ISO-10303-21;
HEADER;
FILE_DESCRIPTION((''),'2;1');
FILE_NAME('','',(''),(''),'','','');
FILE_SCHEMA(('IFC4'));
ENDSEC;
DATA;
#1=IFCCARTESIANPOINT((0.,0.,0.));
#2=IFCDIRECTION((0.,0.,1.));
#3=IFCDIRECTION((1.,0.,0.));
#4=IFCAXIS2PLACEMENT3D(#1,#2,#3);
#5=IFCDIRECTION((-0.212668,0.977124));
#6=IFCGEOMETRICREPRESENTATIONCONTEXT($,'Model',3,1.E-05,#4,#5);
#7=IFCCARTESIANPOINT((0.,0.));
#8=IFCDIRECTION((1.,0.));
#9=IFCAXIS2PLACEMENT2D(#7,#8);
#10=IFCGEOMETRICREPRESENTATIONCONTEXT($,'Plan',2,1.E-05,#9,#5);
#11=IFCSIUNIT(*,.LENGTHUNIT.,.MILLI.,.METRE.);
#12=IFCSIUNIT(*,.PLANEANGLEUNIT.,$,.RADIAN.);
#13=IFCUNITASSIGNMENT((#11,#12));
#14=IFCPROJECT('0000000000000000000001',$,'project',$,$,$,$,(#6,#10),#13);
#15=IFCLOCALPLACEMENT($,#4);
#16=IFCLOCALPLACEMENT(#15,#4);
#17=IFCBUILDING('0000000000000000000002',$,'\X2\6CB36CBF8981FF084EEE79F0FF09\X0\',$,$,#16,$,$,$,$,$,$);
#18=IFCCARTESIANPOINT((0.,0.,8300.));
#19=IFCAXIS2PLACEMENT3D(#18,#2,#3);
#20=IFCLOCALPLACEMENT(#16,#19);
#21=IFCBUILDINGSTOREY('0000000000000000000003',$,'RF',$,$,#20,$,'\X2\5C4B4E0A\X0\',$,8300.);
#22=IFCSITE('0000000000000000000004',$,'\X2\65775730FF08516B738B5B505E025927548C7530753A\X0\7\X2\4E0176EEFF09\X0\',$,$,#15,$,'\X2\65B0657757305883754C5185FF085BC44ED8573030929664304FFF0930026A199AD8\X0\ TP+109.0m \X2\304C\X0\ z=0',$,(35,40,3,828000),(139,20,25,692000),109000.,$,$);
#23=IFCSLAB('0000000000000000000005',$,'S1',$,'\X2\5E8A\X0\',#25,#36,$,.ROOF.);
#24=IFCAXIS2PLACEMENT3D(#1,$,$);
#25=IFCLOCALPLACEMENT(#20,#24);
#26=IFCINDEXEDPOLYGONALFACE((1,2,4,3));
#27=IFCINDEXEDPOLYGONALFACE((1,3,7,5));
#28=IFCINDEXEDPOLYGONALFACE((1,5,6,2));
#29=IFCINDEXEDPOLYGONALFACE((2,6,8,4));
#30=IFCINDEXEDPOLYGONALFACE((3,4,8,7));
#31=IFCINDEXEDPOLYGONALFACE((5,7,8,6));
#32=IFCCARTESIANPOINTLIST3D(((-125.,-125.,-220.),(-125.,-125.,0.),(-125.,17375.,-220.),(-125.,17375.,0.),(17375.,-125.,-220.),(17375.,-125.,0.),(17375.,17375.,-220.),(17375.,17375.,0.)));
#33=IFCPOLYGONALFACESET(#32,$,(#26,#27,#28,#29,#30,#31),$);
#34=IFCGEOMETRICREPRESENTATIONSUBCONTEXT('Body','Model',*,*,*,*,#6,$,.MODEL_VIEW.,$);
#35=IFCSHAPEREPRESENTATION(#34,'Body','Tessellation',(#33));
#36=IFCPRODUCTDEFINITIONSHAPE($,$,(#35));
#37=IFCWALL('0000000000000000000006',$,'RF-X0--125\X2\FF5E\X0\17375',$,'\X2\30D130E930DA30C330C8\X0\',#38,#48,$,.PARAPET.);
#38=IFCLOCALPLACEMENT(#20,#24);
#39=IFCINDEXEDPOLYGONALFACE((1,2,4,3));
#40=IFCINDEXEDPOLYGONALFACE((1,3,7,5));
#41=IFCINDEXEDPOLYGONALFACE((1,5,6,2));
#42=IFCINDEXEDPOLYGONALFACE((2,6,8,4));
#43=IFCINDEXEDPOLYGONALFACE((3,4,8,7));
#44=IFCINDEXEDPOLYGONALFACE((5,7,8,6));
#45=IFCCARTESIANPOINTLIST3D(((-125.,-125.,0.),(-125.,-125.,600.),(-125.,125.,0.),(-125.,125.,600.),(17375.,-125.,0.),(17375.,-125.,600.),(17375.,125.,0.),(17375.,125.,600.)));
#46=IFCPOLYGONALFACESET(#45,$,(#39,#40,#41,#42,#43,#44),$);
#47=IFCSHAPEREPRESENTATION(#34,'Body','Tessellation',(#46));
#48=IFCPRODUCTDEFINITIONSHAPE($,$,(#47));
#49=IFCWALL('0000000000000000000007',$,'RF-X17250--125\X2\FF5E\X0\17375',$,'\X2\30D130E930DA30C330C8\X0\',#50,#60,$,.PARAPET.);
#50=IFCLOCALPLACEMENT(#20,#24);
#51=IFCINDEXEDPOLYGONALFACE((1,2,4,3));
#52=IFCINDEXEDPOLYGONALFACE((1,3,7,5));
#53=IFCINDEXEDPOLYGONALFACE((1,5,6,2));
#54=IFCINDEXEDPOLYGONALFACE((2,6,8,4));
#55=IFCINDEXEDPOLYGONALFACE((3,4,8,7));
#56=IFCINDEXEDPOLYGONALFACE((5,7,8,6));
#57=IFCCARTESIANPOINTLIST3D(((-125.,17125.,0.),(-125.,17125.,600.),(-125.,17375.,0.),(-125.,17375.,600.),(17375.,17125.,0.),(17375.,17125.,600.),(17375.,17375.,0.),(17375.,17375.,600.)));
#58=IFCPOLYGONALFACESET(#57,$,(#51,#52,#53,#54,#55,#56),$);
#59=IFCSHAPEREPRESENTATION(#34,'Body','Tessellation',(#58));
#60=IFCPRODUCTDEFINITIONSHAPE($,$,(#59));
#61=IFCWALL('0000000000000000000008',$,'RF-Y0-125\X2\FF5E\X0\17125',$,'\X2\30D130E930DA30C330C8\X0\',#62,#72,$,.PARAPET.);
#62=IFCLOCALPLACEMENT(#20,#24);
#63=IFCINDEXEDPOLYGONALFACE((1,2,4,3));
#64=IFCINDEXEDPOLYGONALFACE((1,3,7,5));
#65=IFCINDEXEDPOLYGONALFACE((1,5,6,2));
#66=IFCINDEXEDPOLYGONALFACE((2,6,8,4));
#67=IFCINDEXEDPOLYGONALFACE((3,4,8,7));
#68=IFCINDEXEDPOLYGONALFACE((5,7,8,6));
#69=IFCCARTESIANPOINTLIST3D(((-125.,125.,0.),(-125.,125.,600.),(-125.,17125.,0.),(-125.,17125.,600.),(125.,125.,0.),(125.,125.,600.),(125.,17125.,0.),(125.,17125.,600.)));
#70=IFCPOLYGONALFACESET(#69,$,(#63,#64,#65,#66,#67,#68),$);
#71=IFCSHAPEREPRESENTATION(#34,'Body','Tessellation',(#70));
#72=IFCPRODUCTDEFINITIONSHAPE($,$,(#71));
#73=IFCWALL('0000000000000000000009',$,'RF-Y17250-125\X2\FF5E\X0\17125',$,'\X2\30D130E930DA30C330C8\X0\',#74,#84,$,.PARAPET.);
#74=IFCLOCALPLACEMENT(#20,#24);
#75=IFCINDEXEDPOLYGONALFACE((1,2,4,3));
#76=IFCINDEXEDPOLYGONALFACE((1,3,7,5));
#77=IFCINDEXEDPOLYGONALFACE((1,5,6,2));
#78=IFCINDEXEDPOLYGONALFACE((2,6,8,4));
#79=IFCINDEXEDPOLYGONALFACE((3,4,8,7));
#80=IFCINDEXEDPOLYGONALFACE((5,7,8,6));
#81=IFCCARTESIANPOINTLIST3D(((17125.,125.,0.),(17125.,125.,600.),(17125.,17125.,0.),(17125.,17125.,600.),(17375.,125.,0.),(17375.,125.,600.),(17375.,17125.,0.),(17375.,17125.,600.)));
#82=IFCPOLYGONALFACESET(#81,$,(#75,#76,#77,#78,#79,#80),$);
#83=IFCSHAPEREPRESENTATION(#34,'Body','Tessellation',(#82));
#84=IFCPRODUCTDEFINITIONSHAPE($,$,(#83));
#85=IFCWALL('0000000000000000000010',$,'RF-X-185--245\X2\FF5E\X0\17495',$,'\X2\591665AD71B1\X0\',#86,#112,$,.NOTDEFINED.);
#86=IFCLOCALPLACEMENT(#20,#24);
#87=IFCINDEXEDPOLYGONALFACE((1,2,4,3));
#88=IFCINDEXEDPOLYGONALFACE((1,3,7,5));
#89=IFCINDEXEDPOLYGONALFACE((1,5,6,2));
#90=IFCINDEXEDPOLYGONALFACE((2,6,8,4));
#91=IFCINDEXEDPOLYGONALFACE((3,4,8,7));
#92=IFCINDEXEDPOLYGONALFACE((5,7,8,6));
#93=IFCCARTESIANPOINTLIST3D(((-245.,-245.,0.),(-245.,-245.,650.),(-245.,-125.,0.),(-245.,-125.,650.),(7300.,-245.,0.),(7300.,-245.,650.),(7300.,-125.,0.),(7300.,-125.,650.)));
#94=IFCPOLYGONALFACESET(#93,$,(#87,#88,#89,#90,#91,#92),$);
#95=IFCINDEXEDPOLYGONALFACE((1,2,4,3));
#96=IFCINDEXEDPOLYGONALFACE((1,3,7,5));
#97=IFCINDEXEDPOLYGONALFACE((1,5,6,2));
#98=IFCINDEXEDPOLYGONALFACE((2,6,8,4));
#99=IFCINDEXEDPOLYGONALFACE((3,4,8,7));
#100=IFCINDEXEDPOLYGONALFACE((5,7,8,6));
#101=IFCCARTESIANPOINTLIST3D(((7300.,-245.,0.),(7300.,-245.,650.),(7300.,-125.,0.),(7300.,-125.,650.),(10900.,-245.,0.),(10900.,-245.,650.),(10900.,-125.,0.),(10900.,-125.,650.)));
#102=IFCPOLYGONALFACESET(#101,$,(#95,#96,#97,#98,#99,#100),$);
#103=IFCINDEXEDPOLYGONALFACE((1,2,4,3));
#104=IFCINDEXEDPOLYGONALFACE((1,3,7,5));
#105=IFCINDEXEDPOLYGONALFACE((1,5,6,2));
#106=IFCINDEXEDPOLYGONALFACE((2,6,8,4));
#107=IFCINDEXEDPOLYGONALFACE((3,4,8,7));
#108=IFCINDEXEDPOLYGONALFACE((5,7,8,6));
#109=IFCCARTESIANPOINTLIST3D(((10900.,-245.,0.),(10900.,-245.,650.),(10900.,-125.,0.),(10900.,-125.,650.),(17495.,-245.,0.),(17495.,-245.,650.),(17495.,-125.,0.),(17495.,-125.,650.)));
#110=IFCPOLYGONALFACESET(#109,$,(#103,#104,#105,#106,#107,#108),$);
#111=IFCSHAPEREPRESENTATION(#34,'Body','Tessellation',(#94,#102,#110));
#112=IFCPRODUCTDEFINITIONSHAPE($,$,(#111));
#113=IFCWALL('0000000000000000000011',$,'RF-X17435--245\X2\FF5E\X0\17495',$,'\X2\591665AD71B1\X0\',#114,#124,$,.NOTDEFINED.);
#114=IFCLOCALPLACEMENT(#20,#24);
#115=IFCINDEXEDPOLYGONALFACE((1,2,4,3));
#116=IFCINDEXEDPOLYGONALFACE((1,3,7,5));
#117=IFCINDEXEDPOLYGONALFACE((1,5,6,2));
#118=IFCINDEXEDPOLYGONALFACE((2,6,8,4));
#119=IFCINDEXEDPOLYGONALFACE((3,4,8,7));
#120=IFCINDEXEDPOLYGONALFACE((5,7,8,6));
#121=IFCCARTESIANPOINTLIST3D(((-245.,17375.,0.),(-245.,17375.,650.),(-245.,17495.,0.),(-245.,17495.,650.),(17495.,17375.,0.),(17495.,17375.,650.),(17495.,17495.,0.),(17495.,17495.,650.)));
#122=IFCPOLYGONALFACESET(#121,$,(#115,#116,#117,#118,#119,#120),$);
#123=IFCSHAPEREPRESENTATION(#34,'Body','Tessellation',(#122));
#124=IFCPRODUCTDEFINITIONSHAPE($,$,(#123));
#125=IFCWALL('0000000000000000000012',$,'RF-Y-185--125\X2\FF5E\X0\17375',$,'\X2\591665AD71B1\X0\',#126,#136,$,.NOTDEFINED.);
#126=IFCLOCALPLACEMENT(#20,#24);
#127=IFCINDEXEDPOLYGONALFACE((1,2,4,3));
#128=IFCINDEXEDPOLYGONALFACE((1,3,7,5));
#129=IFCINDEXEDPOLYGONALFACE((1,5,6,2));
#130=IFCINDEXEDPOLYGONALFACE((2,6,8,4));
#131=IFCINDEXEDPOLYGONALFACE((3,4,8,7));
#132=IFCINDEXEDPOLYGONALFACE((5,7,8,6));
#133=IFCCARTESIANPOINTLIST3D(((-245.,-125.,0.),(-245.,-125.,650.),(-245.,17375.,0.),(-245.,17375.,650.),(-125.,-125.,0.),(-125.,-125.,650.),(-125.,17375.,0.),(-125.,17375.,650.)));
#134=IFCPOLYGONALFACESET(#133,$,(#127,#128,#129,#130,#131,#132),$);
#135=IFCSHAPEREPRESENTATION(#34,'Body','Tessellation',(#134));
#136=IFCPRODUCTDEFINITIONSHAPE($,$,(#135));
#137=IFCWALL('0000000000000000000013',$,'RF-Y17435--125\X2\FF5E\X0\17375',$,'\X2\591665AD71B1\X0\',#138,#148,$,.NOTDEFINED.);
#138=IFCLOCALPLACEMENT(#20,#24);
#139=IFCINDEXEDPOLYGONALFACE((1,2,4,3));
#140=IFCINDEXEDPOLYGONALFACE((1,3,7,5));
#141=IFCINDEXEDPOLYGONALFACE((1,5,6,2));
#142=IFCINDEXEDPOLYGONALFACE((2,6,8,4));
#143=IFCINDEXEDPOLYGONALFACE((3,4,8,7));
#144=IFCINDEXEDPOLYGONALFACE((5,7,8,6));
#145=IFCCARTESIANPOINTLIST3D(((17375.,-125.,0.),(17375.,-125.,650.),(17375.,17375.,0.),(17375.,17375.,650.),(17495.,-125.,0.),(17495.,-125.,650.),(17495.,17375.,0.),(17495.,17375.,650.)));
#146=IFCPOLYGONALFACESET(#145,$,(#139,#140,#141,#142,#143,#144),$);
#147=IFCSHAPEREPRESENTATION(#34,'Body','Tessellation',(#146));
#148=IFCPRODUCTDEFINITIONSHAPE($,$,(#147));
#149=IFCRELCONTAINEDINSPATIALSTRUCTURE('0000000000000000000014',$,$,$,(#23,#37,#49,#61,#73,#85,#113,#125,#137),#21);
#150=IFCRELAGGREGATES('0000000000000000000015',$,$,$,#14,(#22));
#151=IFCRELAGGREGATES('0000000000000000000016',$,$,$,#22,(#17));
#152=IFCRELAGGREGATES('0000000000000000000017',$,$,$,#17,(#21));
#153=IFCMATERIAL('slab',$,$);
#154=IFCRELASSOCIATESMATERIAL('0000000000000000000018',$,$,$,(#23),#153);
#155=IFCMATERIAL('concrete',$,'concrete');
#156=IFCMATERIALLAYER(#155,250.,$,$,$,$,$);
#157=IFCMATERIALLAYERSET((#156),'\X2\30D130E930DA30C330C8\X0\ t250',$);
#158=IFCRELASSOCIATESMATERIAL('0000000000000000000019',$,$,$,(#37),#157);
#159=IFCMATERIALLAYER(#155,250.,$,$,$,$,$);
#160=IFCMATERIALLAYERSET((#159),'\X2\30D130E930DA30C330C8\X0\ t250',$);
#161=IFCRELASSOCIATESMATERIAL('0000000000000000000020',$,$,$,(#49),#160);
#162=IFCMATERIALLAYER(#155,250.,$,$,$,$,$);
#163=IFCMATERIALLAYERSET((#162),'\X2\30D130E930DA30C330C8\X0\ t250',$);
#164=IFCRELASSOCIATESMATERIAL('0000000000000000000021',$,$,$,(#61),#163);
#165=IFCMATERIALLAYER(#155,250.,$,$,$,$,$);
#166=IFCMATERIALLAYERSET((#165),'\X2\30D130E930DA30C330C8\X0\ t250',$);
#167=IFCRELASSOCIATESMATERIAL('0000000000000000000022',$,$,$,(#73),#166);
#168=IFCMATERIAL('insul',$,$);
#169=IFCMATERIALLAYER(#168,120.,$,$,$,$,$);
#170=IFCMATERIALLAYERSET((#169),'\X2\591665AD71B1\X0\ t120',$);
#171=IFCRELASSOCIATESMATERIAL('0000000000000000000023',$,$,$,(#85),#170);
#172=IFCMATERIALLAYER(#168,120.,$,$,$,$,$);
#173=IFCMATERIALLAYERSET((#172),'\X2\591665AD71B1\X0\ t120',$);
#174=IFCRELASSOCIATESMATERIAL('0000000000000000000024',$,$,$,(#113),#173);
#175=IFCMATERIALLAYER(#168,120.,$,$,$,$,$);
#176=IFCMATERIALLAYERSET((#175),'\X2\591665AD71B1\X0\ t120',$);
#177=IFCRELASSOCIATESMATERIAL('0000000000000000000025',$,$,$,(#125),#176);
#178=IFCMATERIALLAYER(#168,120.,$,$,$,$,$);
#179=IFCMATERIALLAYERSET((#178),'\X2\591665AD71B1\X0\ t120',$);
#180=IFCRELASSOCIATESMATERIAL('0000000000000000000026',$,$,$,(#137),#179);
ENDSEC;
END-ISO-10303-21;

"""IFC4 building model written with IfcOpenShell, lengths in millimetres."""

from ifc_helpers import new_model, si_unit, direction, frame, frame_2d, origin, origin_with_axes, origin_2d_with_axis, place, context, subcontext, project, spatial, rectangle, extrude, material, layer, layer_set, layer_usage, element, save


model = new_model("IFC4")

# Units and contexts
model_context = context("Model", 3, precision=1e-05, world=origin_with_axes(), true_north=direction((-0.212668, 0.977124)))
plan_context = context("Plan", 2, precision=1e-05, world=origin_2d_with_axis(), true_north=direction((-0.212668, 0.977124)))
body_context = subcontext(model_context, "Body", "Model", "MODEL_VIEW")
ifc_project = project(units=[si_unit("LENGTHUNIT", "METRE", prefix="MILLI"), si_unit("PLANEANGLEUNIT", "RADIAN")], contexts=[model_context, plan_context])

# Site, building, storey
site_placement = place(None, origin_with_axes())
site = spatial("IfcSite", under=ifc_project, at=site_placement, Name="敷地（八王子市大和田町7丁目）", LongName="新敷地境界内（寄付地を除く）。標高 TP+109.0m が z=0", RefLatitude=(35, 40, 3, 828000), RefLongitude=(139, 20, 25, 692000), RefElevation=109000.0)
building_placement = place(site_placement, origin_with_axes())
building = spatial("IfcBuilding", under=site, at=building_placement, Name="河沿要（仮称）")
storey_placement = place(building_placement, frame((0.0, 0.0, 8300.0), z_axis=(0.0, 0.0, 1.0), x_axis=(1.0, 0.0, 0.0)))
storey = spatial("IfcBuildingStorey", under=building, at=storey_placement, Name="RF", LongName="屋上", Elevation=8300.0)

# Slab
ifc_material_1 = material(Name="slab")
slab_placement = place(storey_placement, origin_with_axes())
element("IfcSlab", 1, at=slab_placement, inside=storey, material=ifc_material_1, Name="S1", ObjectType="床", PredefinedType="ROOF", context=body_context, shape_type="SweptSolid", body=[
    extrude(rectangle(XDim=17500.0, YDim=17500.0, at=frame_2d((8625.0, 8625.0))), frame((0.0, 0.0, -220.0)), (0.0, 0.0, 1.0), 220.0),
])

# Walls
ifc_material_2 = material(Name="concrete", Category="concrete")
ifc_layer_1 = layer(ifc_material_2, 250.0)
ifc_layer_set_1 = layer_set([ifc_layer_1], Name="パラペット t250")
ifc_layer_usage_1 = layer_usage(ifc_layer_set_1, "AXIS2", "POSITIVE", 0.0)
wall_1_placement = place(storey_placement, origin_with_axes())
element("IfcWall", 2, at=wall_1_placement, inside=storey, material=ifc_layer_usage_1, Name="RF-X0--125～17375", ObjectType="パラペット", PredefinedType="PARAPET", context=body_context, shape_type="SweptSolid", body=[
    extrude(rectangle(XDim=17500.0, YDim=250.0, at=frame_2d((8625.0, 0.0))), origin(), (0.0, 0.0, 1.0), 600.0),
])
ifc_layer_2 = layer(ifc_material_2, 250.0)
ifc_layer_set_2 = layer_set([ifc_layer_2], Name="パラペット t250")
ifc_layer_usage_2 = layer_usage(ifc_layer_set_2, "AXIS2", "POSITIVE", 0.0)
wall_2_placement = place(storey_placement, origin_with_axes())
element("IfcWall", 3, at=wall_2_placement, inside=storey, material=ifc_layer_usage_2, Name="RF-X17250--125～17375", ObjectType="パラペット", PredefinedType="PARAPET", context=body_context, shape_type="SweptSolid", body=[
    extrude(rectangle(XDim=17500.0, YDim=250.0, at=frame_2d((8625.0, 17250.0))), origin(), (0.0, 0.0, 1.0), 600.0),
])
ifc_layer_3 = layer(ifc_material_2, 250.0)
ifc_layer_set_3 = layer_set([ifc_layer_3], Name="パラペット t250")
ifc_layer_usage_3 = layer_usage(ifc_layer_set_3, "AXIS2", "POSITIVE", 0.0)
wall_3_placement = place(storey_placement, origin_with_axes())
element("IfcWall", 4, at=wall_3_placement, inside=storey, material=ifc_layer_usage_3, Name="RF-Y0-125～17125", ObjectType="パラペット", PredefinedType="PARAPET", context=body_context, shape_type="SweptSolid", body=[
    extrude(rectangle(XDim=250.0, YDim=17000.0, at=frame_2d((0.0, 8625.0))), origin(), (0.0, 0.0, 1.0), 600.0),
])
ifc_layer_4 = layer(ifc_material_2, 250.0)
ifc_layer_set_4 = layer_set([ifc_layer_4], Name="パラペット t250")
ifc_layer_usage_4 = layer_usage(ifc_layer_set_4, "AXIS2", "POSITIVE", 0.0)
wall_4_placement = place(storey_placement, origin_with_axes())
element("IfcWall", 5, at=wall_4_placement, inside=storey, material=ifc_layer_usage_4, Name="RF-Y17250-125～17125", ObjectType="パラペット", PredefinedType="PARAPET", context=body_context, shape_type="SweptSolid", body=[
    extrude(rectangle(XDim=250.0, YDim=17000.0, at=frame_2d((17250.0, 8625.0))), origin(), (0.0, 0.0, 1.0), 600.0),
])
ifc_material_3 = material(Name="insul")
ifc_layer_5 = layer(ifc_material_3, 120.0)
ifc_layer_set_5 = layer_set([ifc_layer_5], Name="外断熱 t120")
ifc_layer_usage_5 = layer_usage(ifc_layer_set_5, "AXIS2", "POSITIVE", 0.0)
wall_5_placement = place(storey_placement, origin_with_axes())
element("IfcWall", 6, at=wall_5_placement, inside=storey, material=ifc_layer_usage_5, Name="RF-X-185--245～17495", ObjectType="外断熱", PredefinedType="NOTDEFINED", context=body_context, shape_type="SweptSolid", body=[
    extrude(rectangle(XDim=7545.0, YDim=120.0, at=frame_2d((3527.5, -185.0))), origin(), (0.0, 0.0, 1.0), 650.0),
    extrude(rectangle(XDim=3600.0, YDim=120.0, at=frame_2d((9100.0, -185.0))), origin(), (0.0, 0.0, 1.0), 650.0),
    extrude(rectangle(XDim=6595.0, YDim=120.0, at=frame_2d((14197.5, -185.0))), origin(), (0.0, 0.0, 1.0), 650.0),
])
ifc_layer_6 = layer(ifc_material_3, 120.0)
ifc_layer_set_6 = layer_set([ifc_layer_6], Name="外断熱 t120")
ifc_layer_usage_6 = layer_usage(ifc_layer_set_6, "AXIS2", "POSITIVE", 0.0)
wall_6_placement = place(storey_placement, origin_with_axes())
element("IfcWall", 7, at=wall_6_placement, inside=storey, material=ifc_layer_usage_6, Name="RF-X17435--245～17495", ObjectType="外断熱", PredefinedType="NOTDEFINED", context=body_context, shape_type="SweptSolid", body=[
    extrude(rectangle(XDim=17740.0, YDim=120.0, at=frame_2d((8625.0, 17435.0))), origin(), (0.0, 0.0, 1.0), 650.0),
])
ifc_layer_7 = layer(ifc_material_3, 120.0)
ifc_layer_set_7 = layer_set([ifc_layer_7], Name="外断熱 t120")
ifc_layer_usage_7 = layer_usage(ifc_layer_set_7, "AXIS2", "POSITIVE", 0.0)
wall_7_placement = place(storey_placement, origin_with_axes())
element("IfcWall", 8, at=wall_7_placement, inside=storey, material=ifc_layer_usage_7, Name="RF-Y-185--125～17375", ObjectType="外断熱", PredefinedType="NOTDEFINED", context=body_context, shape_type="SweptSolid", body=[
    extrude(rectangle(XDim=120.0, YDim=17500.0, at=frame_2d((-185.0, 8625.0))), origin(), (0.0, 0.0, 1.0), 650.0),
])
ifc_layer_8 = layer(ifc_material_3, 120.0)
ifc_layer_set_8 = layer_set([ifc_layer_8], Name="外断熱 t120")
ifc_layer_usage_8 = layer_usage(ifc_layer_set_8, "AXIS2", "POSITIVE", 0.0)
wall_8_placement = place(storey_placement, origin_with_axes())
element("IfcWall", 9, at=wall_8_placement, inside=storey, material=ifc_layer_usage_8, Name="RF-Y17435--125～17375", ObjectType="外断熱", PredefinedType="NOTDEFINED", context=body_context, shape_type="SweptSolid", body=[
    extrude(rectangle(XDim=120.0, YDim=17500.0, at=frame_2d((17435.0, 8625.0))), origin(), (0.0, 0.0, 1.0), 650.0),
])

save(model, "model.ifc")
